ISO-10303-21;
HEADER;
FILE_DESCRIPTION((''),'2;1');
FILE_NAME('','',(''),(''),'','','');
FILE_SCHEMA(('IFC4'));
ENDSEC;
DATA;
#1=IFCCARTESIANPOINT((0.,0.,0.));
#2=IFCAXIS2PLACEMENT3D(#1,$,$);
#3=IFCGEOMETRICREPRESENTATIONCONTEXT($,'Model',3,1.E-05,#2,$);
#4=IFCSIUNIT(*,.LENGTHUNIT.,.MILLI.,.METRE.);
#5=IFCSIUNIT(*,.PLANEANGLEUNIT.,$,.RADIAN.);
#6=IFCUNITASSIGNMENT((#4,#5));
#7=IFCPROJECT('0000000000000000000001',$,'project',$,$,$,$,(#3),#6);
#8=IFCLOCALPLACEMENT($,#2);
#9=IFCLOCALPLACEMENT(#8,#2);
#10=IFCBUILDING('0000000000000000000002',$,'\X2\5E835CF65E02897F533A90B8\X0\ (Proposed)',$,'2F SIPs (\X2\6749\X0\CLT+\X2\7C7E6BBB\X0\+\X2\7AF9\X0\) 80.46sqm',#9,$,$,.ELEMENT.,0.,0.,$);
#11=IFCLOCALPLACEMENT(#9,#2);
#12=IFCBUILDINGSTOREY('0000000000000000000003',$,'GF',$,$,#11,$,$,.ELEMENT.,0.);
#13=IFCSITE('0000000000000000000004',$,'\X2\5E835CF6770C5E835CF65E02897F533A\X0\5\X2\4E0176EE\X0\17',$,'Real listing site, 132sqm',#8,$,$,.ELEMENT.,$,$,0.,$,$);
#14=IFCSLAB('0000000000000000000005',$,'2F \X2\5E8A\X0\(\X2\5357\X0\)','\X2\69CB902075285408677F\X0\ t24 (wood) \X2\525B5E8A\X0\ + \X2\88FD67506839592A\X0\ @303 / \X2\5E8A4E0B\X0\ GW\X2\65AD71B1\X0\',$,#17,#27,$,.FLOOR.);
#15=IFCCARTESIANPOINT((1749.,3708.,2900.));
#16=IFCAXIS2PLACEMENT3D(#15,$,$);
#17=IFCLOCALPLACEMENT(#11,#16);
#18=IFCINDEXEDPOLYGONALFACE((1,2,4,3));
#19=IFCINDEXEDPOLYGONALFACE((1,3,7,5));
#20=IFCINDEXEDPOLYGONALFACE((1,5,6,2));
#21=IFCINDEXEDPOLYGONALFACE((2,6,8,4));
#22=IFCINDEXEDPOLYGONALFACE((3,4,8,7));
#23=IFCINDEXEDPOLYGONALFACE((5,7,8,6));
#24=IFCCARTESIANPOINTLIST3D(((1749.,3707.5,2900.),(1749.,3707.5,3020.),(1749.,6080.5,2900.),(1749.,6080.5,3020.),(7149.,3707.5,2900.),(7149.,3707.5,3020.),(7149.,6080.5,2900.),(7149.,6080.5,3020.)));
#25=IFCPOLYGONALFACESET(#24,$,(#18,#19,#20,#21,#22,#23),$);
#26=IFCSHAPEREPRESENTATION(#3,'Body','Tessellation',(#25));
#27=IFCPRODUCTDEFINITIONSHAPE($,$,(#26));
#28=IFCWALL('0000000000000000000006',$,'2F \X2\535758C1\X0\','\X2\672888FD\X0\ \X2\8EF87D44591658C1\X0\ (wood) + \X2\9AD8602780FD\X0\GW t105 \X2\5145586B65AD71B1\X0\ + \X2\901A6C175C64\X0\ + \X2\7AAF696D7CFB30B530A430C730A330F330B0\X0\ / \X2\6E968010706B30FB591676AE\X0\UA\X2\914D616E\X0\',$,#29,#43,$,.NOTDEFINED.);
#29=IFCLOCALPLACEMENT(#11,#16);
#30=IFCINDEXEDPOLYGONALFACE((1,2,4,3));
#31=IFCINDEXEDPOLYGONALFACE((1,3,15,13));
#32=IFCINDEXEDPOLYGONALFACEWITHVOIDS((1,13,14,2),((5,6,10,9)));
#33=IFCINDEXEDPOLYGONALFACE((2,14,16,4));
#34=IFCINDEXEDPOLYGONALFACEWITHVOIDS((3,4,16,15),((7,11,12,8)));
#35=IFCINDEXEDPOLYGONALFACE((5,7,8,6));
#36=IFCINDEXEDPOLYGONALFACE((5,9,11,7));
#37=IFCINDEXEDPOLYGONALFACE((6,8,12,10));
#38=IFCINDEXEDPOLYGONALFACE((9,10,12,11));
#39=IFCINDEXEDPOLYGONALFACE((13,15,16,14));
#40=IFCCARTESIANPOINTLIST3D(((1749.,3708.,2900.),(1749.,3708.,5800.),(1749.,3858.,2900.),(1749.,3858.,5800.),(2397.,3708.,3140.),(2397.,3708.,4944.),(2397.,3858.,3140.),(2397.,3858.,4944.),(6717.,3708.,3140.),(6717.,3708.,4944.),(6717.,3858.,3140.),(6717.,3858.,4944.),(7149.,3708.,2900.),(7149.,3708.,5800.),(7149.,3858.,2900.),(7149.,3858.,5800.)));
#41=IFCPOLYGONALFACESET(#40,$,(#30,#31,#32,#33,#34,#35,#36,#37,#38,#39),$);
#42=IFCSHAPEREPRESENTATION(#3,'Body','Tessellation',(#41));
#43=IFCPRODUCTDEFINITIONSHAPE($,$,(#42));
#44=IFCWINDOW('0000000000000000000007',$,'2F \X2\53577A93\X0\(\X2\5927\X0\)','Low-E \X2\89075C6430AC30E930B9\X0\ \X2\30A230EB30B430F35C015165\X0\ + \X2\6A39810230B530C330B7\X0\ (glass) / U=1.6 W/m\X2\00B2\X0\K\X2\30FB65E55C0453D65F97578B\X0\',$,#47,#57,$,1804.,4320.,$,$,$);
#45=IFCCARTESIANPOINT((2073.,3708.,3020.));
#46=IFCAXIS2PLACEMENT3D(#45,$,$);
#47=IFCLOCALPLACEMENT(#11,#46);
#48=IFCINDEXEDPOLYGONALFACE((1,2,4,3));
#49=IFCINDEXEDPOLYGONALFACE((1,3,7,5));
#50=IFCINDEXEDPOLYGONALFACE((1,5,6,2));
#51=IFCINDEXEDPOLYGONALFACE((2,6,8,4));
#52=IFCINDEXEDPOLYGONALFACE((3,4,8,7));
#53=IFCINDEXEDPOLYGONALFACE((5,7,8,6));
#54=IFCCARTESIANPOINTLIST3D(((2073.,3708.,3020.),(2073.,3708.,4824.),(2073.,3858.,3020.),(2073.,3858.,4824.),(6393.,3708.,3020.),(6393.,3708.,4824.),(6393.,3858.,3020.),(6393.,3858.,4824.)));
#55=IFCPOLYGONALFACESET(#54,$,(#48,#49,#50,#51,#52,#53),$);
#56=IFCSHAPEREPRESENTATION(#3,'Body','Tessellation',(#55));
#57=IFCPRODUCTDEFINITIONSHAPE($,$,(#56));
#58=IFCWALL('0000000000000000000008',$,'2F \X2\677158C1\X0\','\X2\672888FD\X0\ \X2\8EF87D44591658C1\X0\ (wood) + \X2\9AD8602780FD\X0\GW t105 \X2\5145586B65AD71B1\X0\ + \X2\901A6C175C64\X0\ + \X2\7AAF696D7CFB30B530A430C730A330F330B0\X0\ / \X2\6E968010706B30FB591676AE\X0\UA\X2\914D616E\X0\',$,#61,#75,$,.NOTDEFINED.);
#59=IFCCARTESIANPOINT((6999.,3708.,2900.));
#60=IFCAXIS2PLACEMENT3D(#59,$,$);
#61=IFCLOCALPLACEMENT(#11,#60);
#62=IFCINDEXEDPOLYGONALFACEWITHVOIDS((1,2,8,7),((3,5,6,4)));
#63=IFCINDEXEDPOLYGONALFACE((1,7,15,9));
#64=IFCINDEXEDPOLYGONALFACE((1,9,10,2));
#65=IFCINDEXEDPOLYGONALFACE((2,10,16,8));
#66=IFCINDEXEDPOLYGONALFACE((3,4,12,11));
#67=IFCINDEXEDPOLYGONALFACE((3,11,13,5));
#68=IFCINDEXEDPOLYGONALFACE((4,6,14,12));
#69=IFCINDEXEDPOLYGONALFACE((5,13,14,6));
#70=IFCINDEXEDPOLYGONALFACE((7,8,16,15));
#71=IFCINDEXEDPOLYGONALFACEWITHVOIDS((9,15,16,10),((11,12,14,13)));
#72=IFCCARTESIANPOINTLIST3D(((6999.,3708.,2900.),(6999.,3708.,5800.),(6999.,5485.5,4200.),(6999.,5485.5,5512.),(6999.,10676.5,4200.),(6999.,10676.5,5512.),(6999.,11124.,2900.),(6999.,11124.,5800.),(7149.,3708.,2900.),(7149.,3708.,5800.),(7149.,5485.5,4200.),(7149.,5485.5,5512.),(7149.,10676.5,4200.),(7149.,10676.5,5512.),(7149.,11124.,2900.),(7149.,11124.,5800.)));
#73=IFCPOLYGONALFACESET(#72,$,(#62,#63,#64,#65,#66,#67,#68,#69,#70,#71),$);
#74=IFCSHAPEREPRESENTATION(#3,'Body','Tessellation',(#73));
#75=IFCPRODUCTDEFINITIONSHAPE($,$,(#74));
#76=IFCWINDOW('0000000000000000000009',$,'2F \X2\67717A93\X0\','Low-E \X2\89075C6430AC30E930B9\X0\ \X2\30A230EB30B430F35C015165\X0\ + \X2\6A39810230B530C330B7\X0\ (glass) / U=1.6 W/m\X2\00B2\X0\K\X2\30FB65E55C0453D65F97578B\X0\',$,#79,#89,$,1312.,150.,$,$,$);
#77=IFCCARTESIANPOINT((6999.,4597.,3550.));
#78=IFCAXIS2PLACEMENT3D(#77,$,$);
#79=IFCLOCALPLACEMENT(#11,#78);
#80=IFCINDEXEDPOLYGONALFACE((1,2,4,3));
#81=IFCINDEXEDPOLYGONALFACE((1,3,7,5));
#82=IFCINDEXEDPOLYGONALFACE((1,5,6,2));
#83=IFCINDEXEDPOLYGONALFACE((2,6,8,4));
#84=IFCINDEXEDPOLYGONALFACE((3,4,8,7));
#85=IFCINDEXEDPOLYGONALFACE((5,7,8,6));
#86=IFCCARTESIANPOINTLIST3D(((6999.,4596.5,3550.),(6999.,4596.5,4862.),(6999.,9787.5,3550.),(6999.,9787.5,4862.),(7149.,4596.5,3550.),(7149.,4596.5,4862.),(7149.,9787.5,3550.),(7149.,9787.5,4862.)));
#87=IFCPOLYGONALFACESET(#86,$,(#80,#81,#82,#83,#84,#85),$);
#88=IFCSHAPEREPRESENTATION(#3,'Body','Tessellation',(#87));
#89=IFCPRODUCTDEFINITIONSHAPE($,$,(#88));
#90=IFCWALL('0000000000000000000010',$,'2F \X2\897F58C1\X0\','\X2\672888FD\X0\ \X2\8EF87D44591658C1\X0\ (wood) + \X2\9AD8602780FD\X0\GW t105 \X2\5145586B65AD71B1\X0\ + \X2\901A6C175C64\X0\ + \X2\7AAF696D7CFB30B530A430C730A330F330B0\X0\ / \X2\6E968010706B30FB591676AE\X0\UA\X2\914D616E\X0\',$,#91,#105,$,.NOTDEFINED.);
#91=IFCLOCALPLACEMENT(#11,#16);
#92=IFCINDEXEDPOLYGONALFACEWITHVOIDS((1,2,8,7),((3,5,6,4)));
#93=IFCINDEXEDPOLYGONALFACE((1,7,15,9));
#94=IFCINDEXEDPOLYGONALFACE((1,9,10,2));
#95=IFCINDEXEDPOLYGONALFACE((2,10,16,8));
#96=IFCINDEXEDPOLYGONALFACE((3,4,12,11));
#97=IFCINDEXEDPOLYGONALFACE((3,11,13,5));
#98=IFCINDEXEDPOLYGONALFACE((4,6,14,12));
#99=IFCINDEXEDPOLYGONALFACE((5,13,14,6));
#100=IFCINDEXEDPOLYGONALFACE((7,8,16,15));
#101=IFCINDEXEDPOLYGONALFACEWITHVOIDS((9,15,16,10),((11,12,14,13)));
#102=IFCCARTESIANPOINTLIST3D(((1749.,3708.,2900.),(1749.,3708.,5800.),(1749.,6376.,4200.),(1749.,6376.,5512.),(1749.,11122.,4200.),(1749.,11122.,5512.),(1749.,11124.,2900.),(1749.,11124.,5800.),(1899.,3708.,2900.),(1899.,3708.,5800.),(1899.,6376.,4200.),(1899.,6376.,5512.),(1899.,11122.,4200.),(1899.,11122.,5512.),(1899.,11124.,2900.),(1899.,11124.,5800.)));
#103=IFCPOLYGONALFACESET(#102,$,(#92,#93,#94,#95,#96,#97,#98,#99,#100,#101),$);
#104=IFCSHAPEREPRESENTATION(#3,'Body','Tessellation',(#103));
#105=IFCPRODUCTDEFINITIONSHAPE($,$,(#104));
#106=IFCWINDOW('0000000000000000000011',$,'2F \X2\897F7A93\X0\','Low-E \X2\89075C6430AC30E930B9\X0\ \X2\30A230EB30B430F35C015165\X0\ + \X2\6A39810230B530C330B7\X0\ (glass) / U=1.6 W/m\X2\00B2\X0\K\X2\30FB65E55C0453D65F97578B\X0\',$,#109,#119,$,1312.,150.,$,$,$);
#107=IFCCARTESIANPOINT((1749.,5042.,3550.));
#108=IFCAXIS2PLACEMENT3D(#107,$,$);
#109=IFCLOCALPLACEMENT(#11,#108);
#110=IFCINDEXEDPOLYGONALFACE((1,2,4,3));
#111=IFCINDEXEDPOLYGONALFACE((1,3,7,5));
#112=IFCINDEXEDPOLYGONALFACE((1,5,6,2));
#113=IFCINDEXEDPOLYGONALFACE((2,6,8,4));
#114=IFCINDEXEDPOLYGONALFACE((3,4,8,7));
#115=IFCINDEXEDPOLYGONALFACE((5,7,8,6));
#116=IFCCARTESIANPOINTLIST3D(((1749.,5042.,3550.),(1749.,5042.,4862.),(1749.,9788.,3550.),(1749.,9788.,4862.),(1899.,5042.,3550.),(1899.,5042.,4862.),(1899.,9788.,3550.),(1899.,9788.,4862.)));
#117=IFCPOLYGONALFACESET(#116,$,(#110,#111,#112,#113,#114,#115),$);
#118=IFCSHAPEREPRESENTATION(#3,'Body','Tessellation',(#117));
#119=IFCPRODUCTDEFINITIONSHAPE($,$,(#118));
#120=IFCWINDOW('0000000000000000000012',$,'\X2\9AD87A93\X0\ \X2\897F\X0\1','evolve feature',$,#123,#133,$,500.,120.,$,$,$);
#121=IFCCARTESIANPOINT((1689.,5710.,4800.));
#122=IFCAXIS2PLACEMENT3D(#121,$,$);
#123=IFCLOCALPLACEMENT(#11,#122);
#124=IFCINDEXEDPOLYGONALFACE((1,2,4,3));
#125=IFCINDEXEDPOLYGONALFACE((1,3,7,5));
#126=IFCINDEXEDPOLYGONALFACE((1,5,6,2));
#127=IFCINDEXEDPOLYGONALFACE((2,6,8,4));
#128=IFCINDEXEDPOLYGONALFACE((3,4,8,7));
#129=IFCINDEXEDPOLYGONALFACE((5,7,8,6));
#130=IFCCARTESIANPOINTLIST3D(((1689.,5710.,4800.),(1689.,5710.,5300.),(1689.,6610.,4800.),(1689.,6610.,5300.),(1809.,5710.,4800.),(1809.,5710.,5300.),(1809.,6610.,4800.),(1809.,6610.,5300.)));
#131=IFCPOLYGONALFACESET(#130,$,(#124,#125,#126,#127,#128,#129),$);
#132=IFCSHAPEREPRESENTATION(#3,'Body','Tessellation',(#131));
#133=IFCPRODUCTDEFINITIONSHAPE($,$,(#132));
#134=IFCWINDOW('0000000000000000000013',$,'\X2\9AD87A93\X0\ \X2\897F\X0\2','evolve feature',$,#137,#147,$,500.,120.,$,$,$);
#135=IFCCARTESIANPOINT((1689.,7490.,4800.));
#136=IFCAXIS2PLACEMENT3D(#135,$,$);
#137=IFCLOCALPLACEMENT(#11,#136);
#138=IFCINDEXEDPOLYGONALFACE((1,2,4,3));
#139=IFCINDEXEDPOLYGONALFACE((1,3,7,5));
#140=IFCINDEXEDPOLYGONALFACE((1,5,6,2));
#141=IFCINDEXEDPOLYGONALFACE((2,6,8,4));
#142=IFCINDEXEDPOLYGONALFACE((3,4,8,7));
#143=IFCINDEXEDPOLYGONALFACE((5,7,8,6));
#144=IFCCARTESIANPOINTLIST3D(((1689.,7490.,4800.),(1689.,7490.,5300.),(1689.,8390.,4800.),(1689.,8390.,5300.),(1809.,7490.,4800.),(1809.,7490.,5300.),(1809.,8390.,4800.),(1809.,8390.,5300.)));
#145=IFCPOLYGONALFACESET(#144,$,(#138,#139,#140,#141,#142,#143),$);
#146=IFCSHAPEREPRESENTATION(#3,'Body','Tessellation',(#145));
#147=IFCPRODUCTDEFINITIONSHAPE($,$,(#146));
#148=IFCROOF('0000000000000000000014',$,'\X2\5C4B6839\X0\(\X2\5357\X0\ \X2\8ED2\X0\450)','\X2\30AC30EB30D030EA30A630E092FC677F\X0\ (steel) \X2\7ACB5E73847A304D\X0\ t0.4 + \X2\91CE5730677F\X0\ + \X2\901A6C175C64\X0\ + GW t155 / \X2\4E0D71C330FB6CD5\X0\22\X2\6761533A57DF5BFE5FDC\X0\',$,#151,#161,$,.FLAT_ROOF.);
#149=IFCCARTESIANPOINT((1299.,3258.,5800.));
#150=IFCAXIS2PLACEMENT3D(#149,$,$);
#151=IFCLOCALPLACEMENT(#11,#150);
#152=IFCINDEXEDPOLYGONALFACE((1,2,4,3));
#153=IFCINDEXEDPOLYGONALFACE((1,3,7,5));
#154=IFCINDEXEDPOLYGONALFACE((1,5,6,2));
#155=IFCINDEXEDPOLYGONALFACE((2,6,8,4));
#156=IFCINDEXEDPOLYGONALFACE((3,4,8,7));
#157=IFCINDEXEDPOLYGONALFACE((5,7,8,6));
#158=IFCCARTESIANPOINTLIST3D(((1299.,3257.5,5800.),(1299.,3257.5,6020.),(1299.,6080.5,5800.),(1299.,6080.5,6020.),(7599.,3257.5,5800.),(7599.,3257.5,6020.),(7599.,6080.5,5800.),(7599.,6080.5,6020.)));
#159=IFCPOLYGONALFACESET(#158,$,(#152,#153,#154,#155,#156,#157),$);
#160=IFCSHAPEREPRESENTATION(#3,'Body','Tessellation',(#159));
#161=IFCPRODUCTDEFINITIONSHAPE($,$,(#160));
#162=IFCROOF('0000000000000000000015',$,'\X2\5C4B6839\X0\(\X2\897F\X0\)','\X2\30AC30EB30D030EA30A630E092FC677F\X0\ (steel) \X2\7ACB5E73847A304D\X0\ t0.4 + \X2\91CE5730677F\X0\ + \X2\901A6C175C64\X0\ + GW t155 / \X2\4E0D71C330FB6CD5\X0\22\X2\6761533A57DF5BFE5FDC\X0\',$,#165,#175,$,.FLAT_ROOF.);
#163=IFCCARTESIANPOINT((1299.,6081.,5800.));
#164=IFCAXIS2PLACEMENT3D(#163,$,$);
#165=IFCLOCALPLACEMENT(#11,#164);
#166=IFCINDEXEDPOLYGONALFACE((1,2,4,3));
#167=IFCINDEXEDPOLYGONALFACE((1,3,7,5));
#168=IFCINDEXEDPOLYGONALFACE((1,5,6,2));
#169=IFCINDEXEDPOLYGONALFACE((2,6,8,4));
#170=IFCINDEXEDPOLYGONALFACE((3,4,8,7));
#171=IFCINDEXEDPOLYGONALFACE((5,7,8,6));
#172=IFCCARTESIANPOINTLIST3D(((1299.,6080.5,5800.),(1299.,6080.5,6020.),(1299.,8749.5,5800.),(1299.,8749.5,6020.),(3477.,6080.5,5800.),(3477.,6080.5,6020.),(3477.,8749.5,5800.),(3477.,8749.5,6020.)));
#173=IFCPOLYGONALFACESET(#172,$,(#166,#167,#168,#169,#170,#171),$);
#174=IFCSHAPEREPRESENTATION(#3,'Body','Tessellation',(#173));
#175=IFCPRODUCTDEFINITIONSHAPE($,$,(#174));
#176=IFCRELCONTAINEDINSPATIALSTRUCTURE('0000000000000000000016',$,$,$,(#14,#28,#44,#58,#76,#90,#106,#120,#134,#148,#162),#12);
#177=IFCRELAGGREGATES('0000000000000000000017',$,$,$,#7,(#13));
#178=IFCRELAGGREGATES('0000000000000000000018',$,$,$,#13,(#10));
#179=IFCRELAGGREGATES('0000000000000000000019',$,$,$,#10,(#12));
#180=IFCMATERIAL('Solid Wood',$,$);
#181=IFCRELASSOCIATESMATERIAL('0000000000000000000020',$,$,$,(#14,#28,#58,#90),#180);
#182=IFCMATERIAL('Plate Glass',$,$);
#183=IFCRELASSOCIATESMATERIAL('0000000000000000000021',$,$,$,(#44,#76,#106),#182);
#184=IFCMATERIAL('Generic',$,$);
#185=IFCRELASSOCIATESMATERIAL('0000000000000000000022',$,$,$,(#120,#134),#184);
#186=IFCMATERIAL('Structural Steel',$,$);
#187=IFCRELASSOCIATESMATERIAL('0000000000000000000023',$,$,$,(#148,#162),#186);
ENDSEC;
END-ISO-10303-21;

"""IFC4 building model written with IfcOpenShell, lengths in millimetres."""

from ifc_helpers import new_model, si_unit, frame, frame_2d, origin, place, context, project, spatial, rectangle, extrude, material, element, fill, save


model = new_model("IFC4")

# Units and contexts
model_context = context("Model", 3, precision=1e-05, world=origin())
ifc_project = project(units=[si_unit("LENGTHUNIT", "METRE", prefix="MILLI"), si_unit("PLANEANGLEUNIT", "RADIAN")], contexts=[model_context])

# Site, building, storey
site_placement = place(None, origin())
site = spatial("IfcSite", under=ifc_project, at=site_placement, Name="広島県広島市西区5丁目17", ObjectType="Real listing site, 132sqm", CompositionType="ELEMENT", RefElevation=0.0)
building_placement = place(site_placement, origin())
building = spatial("IfcBuilding", under=site, at=building_placement, Name="広島市西区邸 (Proposed)", ObjectType="2F SIPs (杉CLT+籾殻+竹) 80.46sqm", CompositionType="ELEMENT", ElevationOfRefHeight=0.0, ElevationOfTerrain=0.0)
storey_placement = place(building_placement, origin())
storey = spatial("IfcBuildingStorey", under=building, at=storey_placement, Name="GF", CompositionType="ELEMENT", Elevation=0.0)

# Slab
ifc_material_1 = material(Name="Solid Wood")
slab_placement = place(storey_placement, frame((1749.0, 3708.0, 2900.0)))
element("IfcSlab", 1, at=slab_placement, inside=storey, material=ifc_material_1, Name="2F 床(南)", Description="構造用合板 t24 (wood) 剛床 + 製材根太 @303 / 床下 GW断熱", PredefinedType="FLOOR", context=model_context, shape_type="SweptSolid", body=[
    extrude(rectangle(XDim=5400.0, YDim=2373.0, at=frame_2d((2700.0, 1186.0))), frame((1749.0, 3708.0, 2900.0)), (0.0, 0.0, 1.0), 120.0),
])

# Walls, openings, windows
wall_1_placement = place(storey_placement, frame((1749.0, 3708.0, 2900.0)))
wall_1 = element("IfcWall", 2, at=wall_1_placement, inside=storey, material=ifc_material_1, Name="2F 南壁", Description="木製 軸組外壁 (wood) + 高性能GW t105 充填断熱 + 通気層 + 窯業系サイディング / 準耐火・外皮UA配慮", PredefinedType="NOTDEFINED", context=model_context, shape_type="SweptSolid", body=[
    extrude(rectangle(XDim=5400.0, YDim=150.0, at=frame_2d((2700.0, 75.0))), frame((1749.0, 3708.0, 2900.0)), (0.0, 0.0, 1.0), 2900.0),
])
opening_1_placement = place(storey_placement, frame((2073.0, 3708.0, 3020.0)))
opening_1 = element("IfcOpeningElement", 3, at=opening_1_placement, cuts=wall_1, PredefinedType="NOTDEFINED", context=model_context, shape_type="SweptSolid", body=[
    extrude(rectangle(XDim=4320.0, YDim=150.0, at=frame_2d((2160.0, 75.0))), frame((2073.0, 3708.0, 3020.0)), (0.0, 0.0, 1.0), 1804.0),
])
ifc_material_2 = material(Name="Plate Glass")
window_1_placement = place(storey_placement, frame((2073.0, 3708.0, 3020.0)))
window_1 = element("IfcWindow", 4, at=window_1_placement, inside=storey, material=ifc_material_2, Name="2F 南窓(大)", Description="Low-E 複層ガラス アルゴン封入 + 樹脂サッシ (glass) / U=1.6 W/m²K・日射取得型", OverallHeight=1804.0, OverallWidth=4320.0, context=model_context, shape_type="SweptSolid", body=[
    extrude(rectangle(XDim=4320.0, YDim=150.0, at=frame_2d((2160.0, 75.0))), frame((2073.0, 3708.0, 3020.0)), (0.0, 0.0, 1.0), 1804.0),
])
fill(opening_1, window_1)
wall_2_placement = place(storey_placement, frame((6999.0, 3708.0, 2900.0)))
wall_2 = element("IfcWall", 5, at=wall_2_placement, inside=storey, material=ifc_material_1, Name="2F 東壁", Description="木製 軸組外壁 (wood) + 高性能GW t105 充填断熱 + 通気層 + 窯業系サイディング / 準耐火・外皮UA配慮", PredefinedType="NOTDEFINED", context=model_context, shape_type="SweptSolid", body=[
    extrude(rectangle(XDim=150.0, YDim=7416.0, at=frame_2d((75.0, 3708.0))), frame((6999.0, 3708.0, 2900.0)), (0.0, 0.0, 1.0), 2900.0),
])
opening_2_placement = place(storey_placement, frame((6999.0, 4597.0, 3550.0)))
opening_2 = element("IfcOpeningElement", 6, at=opening_2_placement, cuts=wall_2, PredefinedType="NOTDEFINED", context=model_context, shape_type="SweptSolid", body=[
    extrude(rectangle(XDim=150.0, YDim=5191.0, at=frame_2d((75.0, 2595.0))), frame((6999.0, 4597.0, 3550.0)), (0.0, 0.0, 1.0), 1312.0),
])
window_2_placement = place(storey_placement, frame((6999.0, 4597.0, 3550.0)))
window_2 = element("IfcWindow", 7, at=window_2_placement, inside=storey, material=ifc_material_2, Name="2F 東窓", Description="Low-E 複層ガラス アルゴン封入 + 樹脂サッシ (glass) / U=1.6 W/m²K・日射取得型", OverallHeight=1312.0, OverallWidth=150.0, context=model_context, shape_type="SweptSolid", body=[
    extrude(rectangle(XDim=150.0, YDim=5191.0, at=frame_2d((75.0, 2595.0))), frame((6999.0, 4597.0, 3550.0)), (0.0, 0.0, 1.0), 1312.0),
])
fill(opening_2, window_2)

# Wall, openings, windows
wall_3_placement = place(storey_placement, frame((1749.0, 3708.0, 2900.0)))
wall_3 = element("IfcWall", 8, at=wall_3_placement, inside=storey, material=ifc_material_1, Name="2F 西壁", Description="木製 軸組外壁 (wood) + 高性能GW t105 充填断熱 + 通気層 + 窯業系サイディング / 準耐火・外皮UA配慮", PredefinedType="NOTDEFINED", context=model_context, shape_type="SweptSolid", body=[
    extrude(rectangle(XDim=150.0, YDim=7416.0, at=frame_2d((75.0, 3708.0))), frame((1749.0, 3708.0, 2900.0)), (0.0, 0.0, 1.0), 2900.0),
])
opening_3_placement = place(storey_placement, frame((1749.0, 5042.0, 3550.0)))
opening_3 = element("IfcOpeningElement", 9, at=opening_3_placement, cuts=wall_3, PredefinedType="NOTDEFINED", context=model_context, shape_type="SweptSolid", body=[
    extrude(rectangle(XDim=150.0, YDim=4746.0, at=frame_2d((75.0, 2373.0))), frame((1749.0, 5042.0, 3550.0)), (0.0, 0.0, 1.0), 1312.0),
])
opening_4_placement = place(storey_placement, frame((1689.0, 5710.0, 4800.0)))
opening_4 = element("IfcOpeningElement", 10, at=opening_4_placement, cuts=wall_3, PredefinedType="NOTDEFINED", context=model_context, shape_type="SweptSolid", body=[
    extrude(rectangle(XDim=120.0, YDim=900.0, at=frame_2d((60.0, 450.0))), frame((1689.0, 5710.0, 4800.0)), (0.0, 0.0, 1.0), 500.0),
])
opening_5_placement = place(storey_placement, frame((1689.0, 7490.0, 4800.0)))
opening_5 = element("IfcOpeningElement", 11, at=opening_5_placement, cuts=wall_3, PredefinedType="NOTDEFINED", context=model_context, shape_type="SweptSolid", body=[
    extrude(rectangle(XDim=120.0, YDim=900.0, at=frame_2d((60.0, 450.0))), frame((1689.0, 7490.0, 4800.0)), (0.0, 0.0, 1.0), 500.0),
])
window_3_placement = place(storey_placement, frame((1749.0, 5042.0, 3550.0)))
window_3 = element("IfcWindow", 12, at=window_3_placement, inside=storey, material=ifc_material_2, Name="2F 西窓", Description="Low-E 複層ガラス アルゴン封入 + 樹脂サッシ (glass) / U=1.6 W/m²K・日射取得型", OverallHeight=1312.0, OverallWidth=150.0, context=model_context, shape_type="SweptSolid", body=[
    extrude(rectangle(XDim=150.0, YDim=4746.0, at=frame_2d((75.0, 2373.0))), frame((1749.0, 5042.0, 3550.0)), (0.0, 0.0, 1.0), 1312.0),
])
fill(opening_3, window_3)
ifc_material_3 = material(Name="Generic")
window_4_placement = place(storey_placement, frame((1689.0, 5710.0, 4800.0)))
window_4 = element("IfcWindow", 13, at=window_4_placement, inside=storey, material=ifc_material_3, Name="高窓 西1", Description="evolve feature", OverallHeight=500.0, OverallWidth=120.0, context=model_context, shape_type="SweptSolid", body=[
    extrude(rectangle(XDim=120.0, YDim=900.0, at=frame_2d((60.0, 450.0))), frame((1689.0, 5710.0, 4800.0)), (0.0, 0.0, 1.0), 500.0),
])
fill(opening_4, window_4)
window_5_placement = place(storey_placement, frame((1689.0, 7490.0, 4800.0)))
window_5 = element("IfcWindow", 14, at=window_5_placement, inside=storey, material=ifc_material_3, Name="高窓 西2", Description="evolve feature", OverallHeight=500.0, OverallWidth=120.0, context=model_context, shape_type="SweptSolid", body=[
    extrude(rectangle(XDim=120.0, YDim=900.0, at=frame_2d((60.0, 450.0))), frame((1689.0, 7490.0, 4800.0)), (0.0, 0.0, 1.0), 500.0),
])
fill(opening_5, window_5)

# Roofs
ifc_material_4 = material(Name="Structural Steel")
roof_1_placement = place(storey_placement, frame((1299.0, 3258.0, 5800.0)))
element("IfcRoof", 15, at=roof_1_placement, inside=storey, material=ifc_material_4, Name="屋根(南 軒450)", Description="ガルバリウム鋼板 (steel) 立平葺き t0.4 + 野地板 + 通気層 + GW t155 / 不燃・法22条区域対応", PredefinedType="FLAT_ROOF", context=model_context, shape_type="SweptSolid", body=[
    extrude(rectangle(XDim=6300.0, YDim=2823.0, at=frame_2d((3150.0, 1411.0))), frame((1299.0, 3258.0, 5800.0)), (0.0, 0.0, 1.0), 220.0),
])
roof_2_placement = place(storey_placement, frame((1299.0, 6081.0, 5800.0)))
element("IfcRoof", 16, at=roof_2_placement, inside=storey, material=ifc_material_4, Name="屋根(西)", Description="ガルバリウム鋼板 (steel) 立平葺き t0.4 + 野地板 + 通気層 + GW t155 / 不燃・法22条区域対応", PredefinedType="FLAT_ROOF", context=model_context, shape_type="SweptSolid", body=[
    extrude(rectangle(XDim=2178.0, YDim=2669.0, at=frame_2d((1089.0, 1334.0))), frame((1299.0, 6081.0, 5800.0)), (0.0, 0.0, 1.0), 220.0),
])

save(model, "model.ifc")
